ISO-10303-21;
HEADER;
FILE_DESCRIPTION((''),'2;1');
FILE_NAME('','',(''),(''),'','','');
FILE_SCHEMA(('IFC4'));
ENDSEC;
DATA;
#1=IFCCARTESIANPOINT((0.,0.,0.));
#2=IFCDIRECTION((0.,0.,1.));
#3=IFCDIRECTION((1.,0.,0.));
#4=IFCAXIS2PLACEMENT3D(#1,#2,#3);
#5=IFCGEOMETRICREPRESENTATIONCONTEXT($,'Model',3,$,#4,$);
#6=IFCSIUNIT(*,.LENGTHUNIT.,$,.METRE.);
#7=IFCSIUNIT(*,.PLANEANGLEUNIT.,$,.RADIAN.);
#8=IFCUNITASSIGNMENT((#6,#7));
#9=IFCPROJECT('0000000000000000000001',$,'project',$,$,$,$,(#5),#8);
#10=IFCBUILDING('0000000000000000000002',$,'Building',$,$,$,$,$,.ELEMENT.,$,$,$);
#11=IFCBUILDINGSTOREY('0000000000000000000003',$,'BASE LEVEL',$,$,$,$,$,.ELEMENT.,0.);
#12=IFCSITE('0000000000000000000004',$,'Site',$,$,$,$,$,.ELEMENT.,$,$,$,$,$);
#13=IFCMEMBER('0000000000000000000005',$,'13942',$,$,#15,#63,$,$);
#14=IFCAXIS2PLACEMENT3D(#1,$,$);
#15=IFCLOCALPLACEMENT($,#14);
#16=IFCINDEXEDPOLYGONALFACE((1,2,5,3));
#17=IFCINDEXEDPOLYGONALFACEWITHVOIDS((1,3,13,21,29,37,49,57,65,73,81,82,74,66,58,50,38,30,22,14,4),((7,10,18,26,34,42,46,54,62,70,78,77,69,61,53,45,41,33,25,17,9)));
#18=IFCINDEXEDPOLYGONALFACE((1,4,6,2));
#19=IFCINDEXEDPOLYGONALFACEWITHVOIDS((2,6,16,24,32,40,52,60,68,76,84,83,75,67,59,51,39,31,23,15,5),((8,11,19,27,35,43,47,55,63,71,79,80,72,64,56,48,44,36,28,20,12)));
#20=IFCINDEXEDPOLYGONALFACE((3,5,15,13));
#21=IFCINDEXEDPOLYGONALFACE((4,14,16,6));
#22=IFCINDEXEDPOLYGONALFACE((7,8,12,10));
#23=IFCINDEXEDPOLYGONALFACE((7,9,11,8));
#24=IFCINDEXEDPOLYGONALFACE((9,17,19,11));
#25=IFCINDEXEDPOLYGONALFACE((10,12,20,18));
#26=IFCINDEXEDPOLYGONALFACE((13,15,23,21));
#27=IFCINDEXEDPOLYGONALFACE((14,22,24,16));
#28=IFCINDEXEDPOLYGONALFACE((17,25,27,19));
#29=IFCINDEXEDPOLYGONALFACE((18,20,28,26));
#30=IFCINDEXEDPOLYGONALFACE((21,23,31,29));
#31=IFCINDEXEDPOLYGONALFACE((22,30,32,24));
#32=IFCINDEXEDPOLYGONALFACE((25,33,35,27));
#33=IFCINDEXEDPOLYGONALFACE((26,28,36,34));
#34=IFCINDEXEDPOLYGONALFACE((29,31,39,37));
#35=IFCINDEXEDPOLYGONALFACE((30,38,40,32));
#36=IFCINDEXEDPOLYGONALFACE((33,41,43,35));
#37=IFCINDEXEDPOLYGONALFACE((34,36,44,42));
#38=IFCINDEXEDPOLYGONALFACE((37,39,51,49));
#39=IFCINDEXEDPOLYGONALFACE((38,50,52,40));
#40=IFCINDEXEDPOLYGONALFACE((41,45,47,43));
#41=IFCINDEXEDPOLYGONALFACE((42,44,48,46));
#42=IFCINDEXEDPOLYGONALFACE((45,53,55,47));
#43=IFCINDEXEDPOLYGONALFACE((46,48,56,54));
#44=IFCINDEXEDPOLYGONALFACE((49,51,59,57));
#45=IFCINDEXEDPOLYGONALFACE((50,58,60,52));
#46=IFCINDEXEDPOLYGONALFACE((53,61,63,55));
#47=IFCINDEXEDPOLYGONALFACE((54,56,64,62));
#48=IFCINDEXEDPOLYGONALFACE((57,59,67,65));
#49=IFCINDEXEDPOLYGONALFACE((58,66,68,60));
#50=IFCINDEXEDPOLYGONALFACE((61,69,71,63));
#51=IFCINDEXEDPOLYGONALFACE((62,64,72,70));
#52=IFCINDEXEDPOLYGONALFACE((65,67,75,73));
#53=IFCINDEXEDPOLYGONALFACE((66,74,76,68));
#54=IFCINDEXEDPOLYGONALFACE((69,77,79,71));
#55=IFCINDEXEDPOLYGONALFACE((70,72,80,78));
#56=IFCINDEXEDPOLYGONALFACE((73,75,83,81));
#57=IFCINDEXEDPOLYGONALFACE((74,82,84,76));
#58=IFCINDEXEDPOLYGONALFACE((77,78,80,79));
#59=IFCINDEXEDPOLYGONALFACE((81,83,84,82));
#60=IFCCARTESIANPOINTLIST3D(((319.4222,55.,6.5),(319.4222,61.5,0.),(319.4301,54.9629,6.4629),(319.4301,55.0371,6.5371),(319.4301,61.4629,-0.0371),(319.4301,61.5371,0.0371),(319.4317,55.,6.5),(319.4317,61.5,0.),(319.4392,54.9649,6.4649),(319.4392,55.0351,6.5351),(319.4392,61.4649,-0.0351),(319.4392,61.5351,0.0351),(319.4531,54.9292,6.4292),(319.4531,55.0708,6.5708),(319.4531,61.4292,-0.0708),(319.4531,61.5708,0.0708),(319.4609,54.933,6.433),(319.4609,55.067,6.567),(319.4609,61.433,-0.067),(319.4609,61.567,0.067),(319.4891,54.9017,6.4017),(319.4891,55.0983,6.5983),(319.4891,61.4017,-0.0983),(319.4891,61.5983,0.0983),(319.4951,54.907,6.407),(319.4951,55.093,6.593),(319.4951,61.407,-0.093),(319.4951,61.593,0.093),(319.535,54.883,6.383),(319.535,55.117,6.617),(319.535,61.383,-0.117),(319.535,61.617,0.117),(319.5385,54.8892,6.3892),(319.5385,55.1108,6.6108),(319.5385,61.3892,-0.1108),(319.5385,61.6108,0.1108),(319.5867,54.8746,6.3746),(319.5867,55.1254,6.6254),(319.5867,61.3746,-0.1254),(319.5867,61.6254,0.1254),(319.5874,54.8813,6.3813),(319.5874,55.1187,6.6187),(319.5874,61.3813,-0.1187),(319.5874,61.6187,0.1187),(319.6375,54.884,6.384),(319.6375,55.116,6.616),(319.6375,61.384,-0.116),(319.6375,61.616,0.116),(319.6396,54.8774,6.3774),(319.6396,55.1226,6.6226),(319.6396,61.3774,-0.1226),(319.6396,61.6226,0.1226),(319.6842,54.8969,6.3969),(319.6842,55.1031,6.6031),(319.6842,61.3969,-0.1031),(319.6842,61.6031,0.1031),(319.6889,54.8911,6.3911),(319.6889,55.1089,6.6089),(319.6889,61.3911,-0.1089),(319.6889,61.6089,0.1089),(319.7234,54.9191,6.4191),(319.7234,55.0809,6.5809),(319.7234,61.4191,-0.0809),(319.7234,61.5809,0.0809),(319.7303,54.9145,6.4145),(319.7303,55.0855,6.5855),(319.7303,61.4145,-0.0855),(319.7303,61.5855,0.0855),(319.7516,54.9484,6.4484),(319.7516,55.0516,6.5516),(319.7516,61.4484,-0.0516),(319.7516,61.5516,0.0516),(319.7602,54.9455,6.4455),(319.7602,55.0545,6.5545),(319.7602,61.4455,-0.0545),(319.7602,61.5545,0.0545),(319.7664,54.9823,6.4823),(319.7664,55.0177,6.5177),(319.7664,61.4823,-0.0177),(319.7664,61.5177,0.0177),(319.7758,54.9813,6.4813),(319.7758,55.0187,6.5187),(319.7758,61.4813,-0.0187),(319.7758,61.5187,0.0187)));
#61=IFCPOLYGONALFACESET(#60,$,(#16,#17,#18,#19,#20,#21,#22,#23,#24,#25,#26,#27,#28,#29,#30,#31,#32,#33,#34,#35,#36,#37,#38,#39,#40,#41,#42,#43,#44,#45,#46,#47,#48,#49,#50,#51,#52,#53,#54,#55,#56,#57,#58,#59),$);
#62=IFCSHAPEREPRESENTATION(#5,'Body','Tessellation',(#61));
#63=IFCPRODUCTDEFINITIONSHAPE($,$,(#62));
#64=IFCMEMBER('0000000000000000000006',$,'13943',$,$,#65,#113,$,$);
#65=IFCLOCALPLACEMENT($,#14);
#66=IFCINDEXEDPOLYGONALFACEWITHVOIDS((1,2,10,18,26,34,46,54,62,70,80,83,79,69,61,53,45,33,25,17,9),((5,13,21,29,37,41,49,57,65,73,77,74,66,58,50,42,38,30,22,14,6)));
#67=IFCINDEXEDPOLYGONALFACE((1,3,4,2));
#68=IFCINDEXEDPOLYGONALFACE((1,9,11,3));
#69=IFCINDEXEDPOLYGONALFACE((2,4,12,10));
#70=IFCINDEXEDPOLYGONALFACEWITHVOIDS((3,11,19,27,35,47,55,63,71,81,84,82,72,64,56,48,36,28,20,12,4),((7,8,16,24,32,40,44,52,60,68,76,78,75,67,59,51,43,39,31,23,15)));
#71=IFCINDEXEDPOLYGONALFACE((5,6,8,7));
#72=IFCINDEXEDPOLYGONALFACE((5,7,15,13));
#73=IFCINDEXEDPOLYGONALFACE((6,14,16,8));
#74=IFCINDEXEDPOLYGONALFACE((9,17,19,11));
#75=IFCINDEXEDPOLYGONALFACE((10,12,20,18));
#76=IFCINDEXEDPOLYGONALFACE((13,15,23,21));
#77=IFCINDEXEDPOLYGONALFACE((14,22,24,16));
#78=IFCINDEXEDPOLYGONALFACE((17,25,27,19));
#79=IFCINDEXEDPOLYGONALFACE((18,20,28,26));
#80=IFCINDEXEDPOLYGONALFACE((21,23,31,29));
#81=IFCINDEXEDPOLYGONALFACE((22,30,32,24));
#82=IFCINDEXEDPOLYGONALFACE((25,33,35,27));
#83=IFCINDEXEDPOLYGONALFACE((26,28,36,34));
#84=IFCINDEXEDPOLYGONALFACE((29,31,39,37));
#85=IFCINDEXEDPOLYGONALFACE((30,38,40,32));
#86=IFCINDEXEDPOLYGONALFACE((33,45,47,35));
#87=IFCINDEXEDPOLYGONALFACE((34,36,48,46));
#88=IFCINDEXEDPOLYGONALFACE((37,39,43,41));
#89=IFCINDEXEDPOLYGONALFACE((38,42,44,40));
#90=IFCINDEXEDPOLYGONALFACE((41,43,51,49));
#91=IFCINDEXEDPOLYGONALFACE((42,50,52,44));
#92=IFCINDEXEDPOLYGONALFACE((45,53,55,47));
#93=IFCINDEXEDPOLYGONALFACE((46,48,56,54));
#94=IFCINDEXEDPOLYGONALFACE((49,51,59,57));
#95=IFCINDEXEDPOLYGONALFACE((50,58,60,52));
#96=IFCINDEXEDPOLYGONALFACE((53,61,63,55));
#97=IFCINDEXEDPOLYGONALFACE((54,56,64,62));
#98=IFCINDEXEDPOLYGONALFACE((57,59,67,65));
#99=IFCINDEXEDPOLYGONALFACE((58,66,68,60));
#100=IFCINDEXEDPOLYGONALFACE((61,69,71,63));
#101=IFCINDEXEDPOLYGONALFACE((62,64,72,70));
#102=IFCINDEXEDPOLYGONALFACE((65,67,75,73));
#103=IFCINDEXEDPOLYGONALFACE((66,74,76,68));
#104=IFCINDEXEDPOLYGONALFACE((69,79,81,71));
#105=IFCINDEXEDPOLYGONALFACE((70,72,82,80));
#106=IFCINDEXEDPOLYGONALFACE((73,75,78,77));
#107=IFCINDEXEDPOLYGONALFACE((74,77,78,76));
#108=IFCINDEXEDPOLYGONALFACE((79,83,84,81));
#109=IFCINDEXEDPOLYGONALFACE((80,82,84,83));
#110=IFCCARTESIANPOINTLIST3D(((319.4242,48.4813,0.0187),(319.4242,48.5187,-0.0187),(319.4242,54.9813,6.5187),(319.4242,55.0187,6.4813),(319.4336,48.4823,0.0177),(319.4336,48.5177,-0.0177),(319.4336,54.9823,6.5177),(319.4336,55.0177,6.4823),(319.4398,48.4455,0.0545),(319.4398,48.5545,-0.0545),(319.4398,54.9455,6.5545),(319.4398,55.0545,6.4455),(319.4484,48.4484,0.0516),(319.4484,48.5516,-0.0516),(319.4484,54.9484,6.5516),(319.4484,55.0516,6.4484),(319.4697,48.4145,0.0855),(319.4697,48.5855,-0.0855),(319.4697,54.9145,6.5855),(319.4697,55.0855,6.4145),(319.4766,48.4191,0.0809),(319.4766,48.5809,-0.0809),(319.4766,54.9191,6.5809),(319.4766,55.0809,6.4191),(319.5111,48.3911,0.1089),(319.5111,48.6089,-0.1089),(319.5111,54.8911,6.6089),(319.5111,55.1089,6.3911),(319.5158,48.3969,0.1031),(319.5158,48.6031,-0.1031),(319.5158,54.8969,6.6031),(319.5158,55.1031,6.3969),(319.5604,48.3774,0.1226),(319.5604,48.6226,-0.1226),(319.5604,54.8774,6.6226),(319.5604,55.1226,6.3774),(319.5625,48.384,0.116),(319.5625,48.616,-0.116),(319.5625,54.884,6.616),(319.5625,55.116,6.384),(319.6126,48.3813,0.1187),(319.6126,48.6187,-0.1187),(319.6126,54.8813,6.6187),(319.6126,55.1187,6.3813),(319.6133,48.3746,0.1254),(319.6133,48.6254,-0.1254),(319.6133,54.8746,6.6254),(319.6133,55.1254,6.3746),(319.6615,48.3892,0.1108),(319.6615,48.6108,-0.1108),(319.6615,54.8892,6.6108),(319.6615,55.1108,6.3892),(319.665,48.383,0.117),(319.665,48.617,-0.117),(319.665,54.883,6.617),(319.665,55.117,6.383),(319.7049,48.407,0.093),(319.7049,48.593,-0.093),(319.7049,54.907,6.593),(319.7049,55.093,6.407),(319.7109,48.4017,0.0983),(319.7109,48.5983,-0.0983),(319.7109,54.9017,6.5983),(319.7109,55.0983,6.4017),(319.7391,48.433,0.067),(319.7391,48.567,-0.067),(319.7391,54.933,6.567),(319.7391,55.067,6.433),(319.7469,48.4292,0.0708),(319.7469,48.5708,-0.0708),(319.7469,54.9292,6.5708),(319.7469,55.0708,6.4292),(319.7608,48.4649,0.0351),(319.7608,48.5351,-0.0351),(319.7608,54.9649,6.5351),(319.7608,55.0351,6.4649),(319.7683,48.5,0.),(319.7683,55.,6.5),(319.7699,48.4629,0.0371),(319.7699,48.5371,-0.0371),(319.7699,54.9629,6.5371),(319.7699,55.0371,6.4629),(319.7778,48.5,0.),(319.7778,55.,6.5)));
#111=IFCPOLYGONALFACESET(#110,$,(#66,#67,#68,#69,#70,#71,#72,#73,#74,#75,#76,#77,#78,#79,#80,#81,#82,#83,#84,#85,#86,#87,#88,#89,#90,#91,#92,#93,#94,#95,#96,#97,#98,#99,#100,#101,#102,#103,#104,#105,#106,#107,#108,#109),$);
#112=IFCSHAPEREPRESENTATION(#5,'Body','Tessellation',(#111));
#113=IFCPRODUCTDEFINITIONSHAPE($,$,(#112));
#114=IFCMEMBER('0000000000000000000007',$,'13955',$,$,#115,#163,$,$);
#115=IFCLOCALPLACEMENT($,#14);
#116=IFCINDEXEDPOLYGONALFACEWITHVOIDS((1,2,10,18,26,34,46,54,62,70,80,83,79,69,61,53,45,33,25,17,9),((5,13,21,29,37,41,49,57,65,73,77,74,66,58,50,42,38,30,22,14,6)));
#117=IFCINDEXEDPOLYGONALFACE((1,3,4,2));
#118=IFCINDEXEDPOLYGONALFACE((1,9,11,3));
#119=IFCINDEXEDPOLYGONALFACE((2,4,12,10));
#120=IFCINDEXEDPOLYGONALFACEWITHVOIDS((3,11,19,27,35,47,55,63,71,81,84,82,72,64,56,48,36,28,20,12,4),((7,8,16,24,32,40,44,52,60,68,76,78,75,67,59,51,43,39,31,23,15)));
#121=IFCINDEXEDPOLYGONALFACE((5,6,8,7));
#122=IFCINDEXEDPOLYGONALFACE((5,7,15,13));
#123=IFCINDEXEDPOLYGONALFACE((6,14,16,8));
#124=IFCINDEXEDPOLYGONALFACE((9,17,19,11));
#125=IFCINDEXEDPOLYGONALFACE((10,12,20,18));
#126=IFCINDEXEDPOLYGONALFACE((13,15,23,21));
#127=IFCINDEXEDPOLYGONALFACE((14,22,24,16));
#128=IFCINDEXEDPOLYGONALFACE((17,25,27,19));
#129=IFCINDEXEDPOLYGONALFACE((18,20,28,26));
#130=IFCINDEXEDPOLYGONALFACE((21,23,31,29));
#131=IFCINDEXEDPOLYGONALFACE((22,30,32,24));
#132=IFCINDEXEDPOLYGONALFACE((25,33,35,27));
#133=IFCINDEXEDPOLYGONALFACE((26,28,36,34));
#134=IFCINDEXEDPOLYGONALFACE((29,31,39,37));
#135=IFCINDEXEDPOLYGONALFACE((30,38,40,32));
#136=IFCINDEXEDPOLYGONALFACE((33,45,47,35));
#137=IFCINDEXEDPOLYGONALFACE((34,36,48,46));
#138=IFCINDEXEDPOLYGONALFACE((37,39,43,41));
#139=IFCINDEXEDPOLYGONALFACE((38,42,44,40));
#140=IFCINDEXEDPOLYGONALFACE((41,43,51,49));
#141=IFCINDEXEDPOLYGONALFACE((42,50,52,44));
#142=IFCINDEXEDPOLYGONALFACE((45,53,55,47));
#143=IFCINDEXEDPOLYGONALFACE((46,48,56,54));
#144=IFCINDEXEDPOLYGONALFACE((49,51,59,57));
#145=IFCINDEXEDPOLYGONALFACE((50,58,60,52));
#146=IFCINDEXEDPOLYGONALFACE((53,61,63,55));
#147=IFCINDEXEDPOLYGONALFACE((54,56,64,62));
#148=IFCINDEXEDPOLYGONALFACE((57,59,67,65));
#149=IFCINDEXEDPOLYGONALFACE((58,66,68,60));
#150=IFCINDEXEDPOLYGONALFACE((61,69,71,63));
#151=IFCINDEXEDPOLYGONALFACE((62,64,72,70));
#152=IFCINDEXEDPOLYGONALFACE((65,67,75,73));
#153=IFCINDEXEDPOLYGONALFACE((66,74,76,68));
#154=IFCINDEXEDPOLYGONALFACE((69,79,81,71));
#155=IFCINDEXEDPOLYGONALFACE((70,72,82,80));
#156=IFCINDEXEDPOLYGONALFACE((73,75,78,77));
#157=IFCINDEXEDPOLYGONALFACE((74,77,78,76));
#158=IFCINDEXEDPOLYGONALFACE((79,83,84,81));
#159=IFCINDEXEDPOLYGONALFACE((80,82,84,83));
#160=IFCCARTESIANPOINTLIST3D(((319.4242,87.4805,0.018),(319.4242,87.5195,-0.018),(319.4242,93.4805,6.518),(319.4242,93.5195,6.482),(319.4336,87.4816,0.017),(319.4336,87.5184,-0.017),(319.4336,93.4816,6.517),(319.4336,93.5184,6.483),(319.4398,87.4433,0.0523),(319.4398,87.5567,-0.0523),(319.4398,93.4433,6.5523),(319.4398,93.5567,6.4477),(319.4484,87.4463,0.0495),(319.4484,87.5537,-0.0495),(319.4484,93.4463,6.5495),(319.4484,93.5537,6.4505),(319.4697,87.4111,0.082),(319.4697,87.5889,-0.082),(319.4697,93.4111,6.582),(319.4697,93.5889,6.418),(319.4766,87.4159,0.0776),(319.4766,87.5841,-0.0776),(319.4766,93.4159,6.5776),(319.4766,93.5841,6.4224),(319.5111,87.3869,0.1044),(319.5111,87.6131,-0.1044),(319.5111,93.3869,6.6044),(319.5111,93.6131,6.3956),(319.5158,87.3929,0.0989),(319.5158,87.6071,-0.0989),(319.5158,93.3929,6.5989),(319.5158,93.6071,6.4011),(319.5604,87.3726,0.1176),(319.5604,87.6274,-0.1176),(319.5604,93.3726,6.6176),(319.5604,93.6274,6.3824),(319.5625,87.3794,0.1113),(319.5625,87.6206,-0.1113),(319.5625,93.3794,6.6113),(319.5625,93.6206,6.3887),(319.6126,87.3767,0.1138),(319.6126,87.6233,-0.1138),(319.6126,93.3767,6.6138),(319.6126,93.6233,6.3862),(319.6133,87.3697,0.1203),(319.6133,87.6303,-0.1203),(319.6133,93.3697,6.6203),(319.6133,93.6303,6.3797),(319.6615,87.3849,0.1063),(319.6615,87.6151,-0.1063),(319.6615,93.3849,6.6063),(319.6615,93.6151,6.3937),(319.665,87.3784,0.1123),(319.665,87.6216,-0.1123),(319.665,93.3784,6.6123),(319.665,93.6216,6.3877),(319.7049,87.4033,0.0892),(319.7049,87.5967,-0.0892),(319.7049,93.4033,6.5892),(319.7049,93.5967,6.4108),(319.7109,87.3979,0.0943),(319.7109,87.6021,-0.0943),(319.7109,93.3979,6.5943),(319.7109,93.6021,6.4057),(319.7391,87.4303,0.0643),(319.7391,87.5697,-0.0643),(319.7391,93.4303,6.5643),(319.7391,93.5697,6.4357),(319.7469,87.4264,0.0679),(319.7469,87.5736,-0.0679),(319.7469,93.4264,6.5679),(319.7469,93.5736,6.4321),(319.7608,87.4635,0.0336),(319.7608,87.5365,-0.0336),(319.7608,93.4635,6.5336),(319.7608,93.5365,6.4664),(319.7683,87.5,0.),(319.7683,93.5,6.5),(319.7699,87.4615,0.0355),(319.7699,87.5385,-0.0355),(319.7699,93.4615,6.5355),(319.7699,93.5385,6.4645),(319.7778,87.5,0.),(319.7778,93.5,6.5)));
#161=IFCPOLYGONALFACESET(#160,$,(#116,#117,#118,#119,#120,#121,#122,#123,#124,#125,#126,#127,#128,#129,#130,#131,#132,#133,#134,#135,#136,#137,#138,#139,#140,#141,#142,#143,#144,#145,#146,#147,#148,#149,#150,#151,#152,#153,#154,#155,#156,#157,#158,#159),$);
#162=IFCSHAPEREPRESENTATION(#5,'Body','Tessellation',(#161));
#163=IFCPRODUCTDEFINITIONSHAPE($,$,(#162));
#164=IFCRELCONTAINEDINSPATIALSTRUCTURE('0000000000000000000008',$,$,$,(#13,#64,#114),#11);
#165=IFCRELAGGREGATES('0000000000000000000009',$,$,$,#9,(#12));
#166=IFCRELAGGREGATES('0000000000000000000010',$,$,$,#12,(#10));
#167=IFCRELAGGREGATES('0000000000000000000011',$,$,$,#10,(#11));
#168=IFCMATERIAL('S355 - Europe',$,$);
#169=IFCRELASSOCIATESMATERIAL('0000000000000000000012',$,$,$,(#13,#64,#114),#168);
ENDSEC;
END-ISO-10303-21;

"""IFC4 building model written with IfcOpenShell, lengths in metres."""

from ifc_helpers import new_model, si_unit, frame, origin_with_axes, origin_2d_with_axis, place, context, project, spatial, hollow_circle, extrude, material, material_profile, profile_set, profile_usage, element, save


model = new_model("IFC4")

# Units and contexts
model_context = context("Model", 3, world=origin_with_axes())
ifc_project = project(units=[si_unit("LENGTHUNIT", "METRE"), si_unit("PLANEANGLEUNIT", "RADIAN")], contexts=[model_context])

# Site, building, storey
site = spatial("IfcSite", under=ifc_project, Name="Site", CompositionType="ELEMENT")
building = spatial("IfcBuilding", under=site, Name="Building", CompositionType="ELEMENT")
storey = spatial("IfcBuildingStorey", under=building, Name="BASE LEVEL", CompositionType="ELEMENT", Elevation=0.0)

# Shared definitions
ifc_material = material(Name="S355 - Europe")

# Members
ifc_material_profile_1 = material_profile(ifc_material, hollow_circle(Radius=0.1778, WallThickness=0.0095, at=origin_2d_with_axis()))
ifc_profile_set_1 = profile_set([ifc_material_profile_1])
ifc_profile_usage_1 = profile_usage(ifc_profile_set_1, cardinal=10)
member_1_placement = place(None, frame((319.6, 55.0, 6.5), z_axis=(0.0, 0.707107, -0.707107), x_axis=(-1.0, 0.0, 0.0)))
element("IfcMember", 1, at=member_1_placement, inside=storey, material=ifc_profile_usage_1, Name="13942", context=model_context, shape_type="SweptSolid", body=[
    extrude(hollow_circle(Radius=0.1778, WallThickness=0.0095, at=origin_2d_with_axis()), origin_with_axes(), (0.0, 0.0, 1.0), 9.1924),
])
ifc_material_profile_2 = material_profile(ifc_material, hollow_circle(Radius=0.1778, WallThickness=0.0095, at=origin_2d_with_axis()))
ifc_profile_set_2 = profile_set([ifc_material_profile_2])
ifc_profile_usage_2 = profile_usage(ifc_profile_set_2, cardinal=10)
member_2_placement = place(None, frame((319.6, 55.0, 6.5), z_axis=(0.0, -0.707107, -0.707107), x_axis=(1.0, 0.0, 0.0)))
element("IfcMember", 2, at=member_2_placement, inside=storey, material=ifc_profile_usage_2, Name="13943", context=model_context, shape_type="SweptSolid", body=[
    extrude(hollow_circle(Radius=0.1778, WallThickness=0.0095, at=origin_2d_with_axis()), origin_with_axes(), (0.0, 0.0, 1.0), 9.1924),
])
ifc_material_profile_3 = material_profile(ifc_material, hollow_circle(Radius=0.1778, WallThickness=0.0095, at=origin_2d_with_axis()))
ifc_profile_set_3 = profile_set([ifc_material_profile_3])
ifc_profile_usage_3 = profile_usage(ifc_profile_set_3, cardinal=10)
member_3_placement = place(None, frame((319.6, 93.5, 6.5), z_axis=(0.0, -0.67828, -0.734803), x_axis=(1.0, 0.0, 0.0)))
element("IfcMember", 3, at=member_3_placement, inside=storey, material=ifc_profile_usage_3, Name="13955", context=model_context, shape_type="SweptSolid", body=[
    extrude(hollow_circle(Radius=0.1778, WallThickness=0.0095, at=origin_2d_with_axis()), origin_with_axes(), (0.0, 0.0, 1.0), 8.8459),
])

save(model, "model.ifc")
